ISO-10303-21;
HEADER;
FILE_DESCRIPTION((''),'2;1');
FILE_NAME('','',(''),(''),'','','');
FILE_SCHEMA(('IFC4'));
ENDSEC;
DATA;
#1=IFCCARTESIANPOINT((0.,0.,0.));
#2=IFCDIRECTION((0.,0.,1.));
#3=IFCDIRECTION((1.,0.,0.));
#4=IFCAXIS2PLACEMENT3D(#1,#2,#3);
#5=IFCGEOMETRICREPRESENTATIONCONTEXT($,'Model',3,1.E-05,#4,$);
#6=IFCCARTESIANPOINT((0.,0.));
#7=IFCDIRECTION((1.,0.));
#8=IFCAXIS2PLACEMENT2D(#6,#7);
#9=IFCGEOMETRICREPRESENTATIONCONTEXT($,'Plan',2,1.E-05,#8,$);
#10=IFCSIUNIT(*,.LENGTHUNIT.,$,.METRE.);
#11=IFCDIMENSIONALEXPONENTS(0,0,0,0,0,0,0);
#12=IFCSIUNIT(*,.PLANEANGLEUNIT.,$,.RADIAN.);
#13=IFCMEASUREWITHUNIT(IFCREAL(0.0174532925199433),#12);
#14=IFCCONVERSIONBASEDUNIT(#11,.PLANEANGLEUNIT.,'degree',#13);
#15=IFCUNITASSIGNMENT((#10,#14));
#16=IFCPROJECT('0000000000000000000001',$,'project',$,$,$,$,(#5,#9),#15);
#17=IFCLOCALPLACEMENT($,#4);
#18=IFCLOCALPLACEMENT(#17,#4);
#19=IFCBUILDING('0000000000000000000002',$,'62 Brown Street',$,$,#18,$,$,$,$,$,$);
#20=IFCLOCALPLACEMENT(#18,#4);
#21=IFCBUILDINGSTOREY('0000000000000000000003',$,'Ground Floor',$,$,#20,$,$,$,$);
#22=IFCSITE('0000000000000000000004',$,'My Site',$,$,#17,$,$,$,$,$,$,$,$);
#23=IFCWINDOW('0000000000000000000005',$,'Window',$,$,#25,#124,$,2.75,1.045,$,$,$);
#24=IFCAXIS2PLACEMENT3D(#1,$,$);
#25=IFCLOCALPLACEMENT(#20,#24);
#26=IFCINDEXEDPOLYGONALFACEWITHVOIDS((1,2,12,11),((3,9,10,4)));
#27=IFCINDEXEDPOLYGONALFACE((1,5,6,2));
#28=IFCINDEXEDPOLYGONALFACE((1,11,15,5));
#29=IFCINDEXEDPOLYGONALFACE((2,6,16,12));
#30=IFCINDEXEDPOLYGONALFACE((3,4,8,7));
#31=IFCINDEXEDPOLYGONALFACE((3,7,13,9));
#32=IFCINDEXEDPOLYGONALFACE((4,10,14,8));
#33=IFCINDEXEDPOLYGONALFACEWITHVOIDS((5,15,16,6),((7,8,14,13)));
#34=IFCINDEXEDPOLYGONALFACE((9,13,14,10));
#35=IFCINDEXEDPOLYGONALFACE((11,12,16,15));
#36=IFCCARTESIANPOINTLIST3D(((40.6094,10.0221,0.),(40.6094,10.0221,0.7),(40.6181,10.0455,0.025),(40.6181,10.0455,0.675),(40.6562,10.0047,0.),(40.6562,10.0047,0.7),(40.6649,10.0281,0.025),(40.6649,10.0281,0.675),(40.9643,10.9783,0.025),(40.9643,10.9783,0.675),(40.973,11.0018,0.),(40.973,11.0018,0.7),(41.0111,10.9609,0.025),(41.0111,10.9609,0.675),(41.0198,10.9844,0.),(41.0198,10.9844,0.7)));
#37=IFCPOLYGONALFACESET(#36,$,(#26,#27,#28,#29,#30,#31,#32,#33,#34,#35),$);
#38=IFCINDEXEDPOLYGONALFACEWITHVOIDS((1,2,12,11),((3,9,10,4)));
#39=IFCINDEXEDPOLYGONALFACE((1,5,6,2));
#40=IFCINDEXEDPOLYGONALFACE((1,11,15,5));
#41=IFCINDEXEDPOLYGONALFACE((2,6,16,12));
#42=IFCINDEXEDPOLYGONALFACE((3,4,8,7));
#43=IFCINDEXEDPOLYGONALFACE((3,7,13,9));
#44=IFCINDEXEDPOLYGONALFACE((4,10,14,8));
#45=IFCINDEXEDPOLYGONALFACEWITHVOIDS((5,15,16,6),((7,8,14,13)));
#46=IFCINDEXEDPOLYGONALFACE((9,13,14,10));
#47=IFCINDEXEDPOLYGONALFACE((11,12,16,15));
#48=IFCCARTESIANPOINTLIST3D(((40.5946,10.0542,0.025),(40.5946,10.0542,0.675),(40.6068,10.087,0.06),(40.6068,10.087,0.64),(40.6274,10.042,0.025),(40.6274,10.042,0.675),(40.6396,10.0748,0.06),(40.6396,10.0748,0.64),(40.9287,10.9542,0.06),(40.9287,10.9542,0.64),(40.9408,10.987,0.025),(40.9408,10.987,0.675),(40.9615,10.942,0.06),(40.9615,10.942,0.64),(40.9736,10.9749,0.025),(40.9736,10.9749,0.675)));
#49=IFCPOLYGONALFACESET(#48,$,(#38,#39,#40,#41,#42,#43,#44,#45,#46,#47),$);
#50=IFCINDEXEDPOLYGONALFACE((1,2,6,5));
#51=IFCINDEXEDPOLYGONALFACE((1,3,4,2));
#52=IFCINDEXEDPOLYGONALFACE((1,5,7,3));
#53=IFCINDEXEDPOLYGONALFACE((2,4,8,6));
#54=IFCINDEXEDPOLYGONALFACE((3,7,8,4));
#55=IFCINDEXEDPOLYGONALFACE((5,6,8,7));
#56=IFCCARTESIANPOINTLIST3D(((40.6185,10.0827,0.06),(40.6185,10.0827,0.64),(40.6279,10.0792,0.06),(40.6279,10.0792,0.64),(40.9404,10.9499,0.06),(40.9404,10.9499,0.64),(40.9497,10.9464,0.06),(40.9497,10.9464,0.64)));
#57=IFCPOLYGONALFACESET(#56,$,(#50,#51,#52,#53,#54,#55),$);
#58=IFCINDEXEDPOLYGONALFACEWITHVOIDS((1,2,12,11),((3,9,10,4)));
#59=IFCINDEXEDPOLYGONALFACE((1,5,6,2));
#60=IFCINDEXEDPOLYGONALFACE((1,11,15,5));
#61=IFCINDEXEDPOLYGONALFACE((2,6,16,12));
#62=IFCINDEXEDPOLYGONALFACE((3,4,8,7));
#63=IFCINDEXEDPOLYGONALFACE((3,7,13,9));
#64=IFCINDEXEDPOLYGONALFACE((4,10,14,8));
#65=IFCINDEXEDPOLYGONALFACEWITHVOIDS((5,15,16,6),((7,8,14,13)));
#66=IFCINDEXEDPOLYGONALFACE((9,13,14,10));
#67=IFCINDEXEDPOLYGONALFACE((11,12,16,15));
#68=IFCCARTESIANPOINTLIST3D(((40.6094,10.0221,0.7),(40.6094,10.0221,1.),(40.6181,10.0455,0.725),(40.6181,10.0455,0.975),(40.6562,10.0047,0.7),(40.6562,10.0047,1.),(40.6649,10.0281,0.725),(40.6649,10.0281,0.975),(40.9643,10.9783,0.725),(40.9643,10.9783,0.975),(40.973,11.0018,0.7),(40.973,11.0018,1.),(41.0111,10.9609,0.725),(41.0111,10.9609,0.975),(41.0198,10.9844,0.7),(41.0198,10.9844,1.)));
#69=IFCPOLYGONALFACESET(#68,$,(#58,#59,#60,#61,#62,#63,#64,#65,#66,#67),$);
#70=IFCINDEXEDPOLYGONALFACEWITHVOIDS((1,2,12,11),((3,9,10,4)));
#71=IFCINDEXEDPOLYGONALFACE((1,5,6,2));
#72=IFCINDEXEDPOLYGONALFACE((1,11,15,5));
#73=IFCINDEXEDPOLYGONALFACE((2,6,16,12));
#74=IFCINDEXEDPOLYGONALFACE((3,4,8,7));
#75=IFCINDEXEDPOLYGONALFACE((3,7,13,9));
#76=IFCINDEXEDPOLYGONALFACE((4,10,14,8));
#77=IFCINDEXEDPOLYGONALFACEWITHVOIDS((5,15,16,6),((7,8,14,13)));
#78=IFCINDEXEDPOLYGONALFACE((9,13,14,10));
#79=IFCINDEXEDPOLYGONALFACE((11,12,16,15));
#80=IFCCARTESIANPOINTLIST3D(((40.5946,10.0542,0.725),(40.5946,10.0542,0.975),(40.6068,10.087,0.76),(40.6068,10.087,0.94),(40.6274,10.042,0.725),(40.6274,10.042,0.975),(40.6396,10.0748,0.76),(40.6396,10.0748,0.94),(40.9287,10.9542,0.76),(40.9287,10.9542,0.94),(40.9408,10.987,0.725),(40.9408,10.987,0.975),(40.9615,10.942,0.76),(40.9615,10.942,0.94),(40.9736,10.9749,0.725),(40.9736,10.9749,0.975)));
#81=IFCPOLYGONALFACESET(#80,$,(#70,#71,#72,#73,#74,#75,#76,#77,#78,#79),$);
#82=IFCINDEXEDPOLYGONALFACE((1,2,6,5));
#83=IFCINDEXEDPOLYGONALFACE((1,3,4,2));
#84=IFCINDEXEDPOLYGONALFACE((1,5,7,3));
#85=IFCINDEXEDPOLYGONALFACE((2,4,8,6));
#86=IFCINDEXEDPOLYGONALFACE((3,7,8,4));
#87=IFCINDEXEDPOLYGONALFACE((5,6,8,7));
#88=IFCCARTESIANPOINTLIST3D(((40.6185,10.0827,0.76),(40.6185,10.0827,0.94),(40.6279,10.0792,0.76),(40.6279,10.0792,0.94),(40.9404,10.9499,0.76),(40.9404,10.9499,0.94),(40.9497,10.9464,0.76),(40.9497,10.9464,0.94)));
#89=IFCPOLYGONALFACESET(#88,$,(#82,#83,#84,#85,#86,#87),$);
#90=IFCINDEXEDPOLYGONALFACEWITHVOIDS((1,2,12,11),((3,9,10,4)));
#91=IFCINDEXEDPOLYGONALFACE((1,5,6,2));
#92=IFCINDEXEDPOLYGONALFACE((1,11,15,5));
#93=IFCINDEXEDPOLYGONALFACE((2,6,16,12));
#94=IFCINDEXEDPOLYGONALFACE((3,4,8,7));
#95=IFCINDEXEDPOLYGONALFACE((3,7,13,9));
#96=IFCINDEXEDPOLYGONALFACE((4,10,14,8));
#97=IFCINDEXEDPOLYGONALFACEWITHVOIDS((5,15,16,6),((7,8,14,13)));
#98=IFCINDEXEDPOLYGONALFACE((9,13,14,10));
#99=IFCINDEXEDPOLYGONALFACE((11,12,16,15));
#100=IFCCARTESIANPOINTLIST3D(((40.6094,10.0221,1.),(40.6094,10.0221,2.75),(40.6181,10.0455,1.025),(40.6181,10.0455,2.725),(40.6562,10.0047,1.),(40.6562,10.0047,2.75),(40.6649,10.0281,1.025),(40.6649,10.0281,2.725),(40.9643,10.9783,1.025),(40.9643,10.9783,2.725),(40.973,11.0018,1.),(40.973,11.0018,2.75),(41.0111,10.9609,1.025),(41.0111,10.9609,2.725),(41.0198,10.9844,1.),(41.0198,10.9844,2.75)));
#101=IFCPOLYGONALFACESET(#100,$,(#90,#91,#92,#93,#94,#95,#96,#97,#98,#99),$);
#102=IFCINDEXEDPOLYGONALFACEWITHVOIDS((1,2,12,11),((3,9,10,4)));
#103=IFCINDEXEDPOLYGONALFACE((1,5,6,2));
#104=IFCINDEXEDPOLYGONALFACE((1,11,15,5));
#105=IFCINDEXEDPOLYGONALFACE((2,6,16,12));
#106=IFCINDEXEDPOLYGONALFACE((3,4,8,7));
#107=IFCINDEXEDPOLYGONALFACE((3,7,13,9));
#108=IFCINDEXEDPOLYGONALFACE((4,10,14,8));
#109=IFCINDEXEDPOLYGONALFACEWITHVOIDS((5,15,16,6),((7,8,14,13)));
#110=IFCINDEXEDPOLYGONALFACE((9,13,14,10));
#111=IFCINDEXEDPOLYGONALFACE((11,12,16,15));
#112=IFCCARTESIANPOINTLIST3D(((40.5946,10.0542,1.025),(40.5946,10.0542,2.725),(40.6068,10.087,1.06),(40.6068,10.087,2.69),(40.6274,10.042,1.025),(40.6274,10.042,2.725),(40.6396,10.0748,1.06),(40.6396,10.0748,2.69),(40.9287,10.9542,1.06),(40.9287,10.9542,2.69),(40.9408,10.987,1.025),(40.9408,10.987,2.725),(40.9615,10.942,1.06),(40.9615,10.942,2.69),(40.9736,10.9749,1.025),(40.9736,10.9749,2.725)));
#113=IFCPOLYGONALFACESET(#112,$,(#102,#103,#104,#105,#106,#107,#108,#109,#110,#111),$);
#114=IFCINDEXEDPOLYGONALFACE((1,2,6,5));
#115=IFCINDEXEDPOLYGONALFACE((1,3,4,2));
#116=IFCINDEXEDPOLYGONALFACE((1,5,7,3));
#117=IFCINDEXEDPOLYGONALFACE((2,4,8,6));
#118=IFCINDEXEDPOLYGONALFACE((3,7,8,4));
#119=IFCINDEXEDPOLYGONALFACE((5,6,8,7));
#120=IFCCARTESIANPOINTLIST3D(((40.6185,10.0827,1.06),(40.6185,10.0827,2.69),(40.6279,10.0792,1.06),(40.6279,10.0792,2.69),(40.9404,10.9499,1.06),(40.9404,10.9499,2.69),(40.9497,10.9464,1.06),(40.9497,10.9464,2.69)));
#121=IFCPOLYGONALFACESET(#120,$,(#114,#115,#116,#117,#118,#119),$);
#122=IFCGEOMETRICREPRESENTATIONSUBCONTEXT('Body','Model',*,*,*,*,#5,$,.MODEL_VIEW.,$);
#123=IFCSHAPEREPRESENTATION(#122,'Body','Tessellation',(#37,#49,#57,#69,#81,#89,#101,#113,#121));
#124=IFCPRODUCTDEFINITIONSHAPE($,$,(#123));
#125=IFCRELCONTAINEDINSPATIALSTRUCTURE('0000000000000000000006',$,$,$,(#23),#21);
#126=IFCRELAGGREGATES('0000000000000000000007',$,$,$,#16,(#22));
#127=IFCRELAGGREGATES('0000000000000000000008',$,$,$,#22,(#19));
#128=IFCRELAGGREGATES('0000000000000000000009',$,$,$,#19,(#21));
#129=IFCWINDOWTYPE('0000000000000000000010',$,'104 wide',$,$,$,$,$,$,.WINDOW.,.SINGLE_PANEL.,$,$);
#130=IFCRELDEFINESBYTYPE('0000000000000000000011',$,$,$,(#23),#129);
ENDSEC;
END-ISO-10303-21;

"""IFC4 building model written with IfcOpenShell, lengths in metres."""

from ifc_helpers import new_model, entity, si_unit, converted_unit, frame, origin_with_axes, origin_2d_with_axis, place, context, subcontext, project, spatial, line, indexed_curve, outline, extrude, shape, source, transform, mapped, type_object, type_shapes, element, save


model = new_model("IFC4")

# Units and contexts
model_context = context("Model", 3, precision=1e-05, world=origin_with_axes())
plan_context = context("Plan", 2, precision=1e-05, world=origin_2d_with_axis())
body_context_1 = subcontext(model_context, "Body", "Model", "MODEL_VIEW")
body_context_2 = subcontext(plan_context, "Body", "Plan", "PLAN_VIEW")
ifc_project = project(units=[si_unit("LENGTHUNIT", "METRE"), converted_unit("PLANEANGLEUNIT", "degree", entity("IfcReal", 0.0174532925199433), si_unit("PLANEANGLEUNIT", "RADIAN"), dimensions=[0, 0, 0, 0, 0, 0, 0])], contexts=[model_context, plan_context])

# Site, building, storey
site_placement = place(None, origin_with_axes())
site = spatial("IfcSite", under=ifc_project, at=site_placement, Name="My Site")
building_placement = place(site_placement, origin_with_axes())
building = spatial("IfcBuilding", under=site, at=building_placement, Name="62 Brown Street")
storey_placement = place(building_placement, origin_with_axes())
storey = spatial("IfcBuildingStorey", under=building, at=storey_placement, Name="Ground Floor")

# Window
window_type_1 = type_object("IfcWindowType", Name="104 wide", PartitioningType="SINGLE_PANEL", PredefinedType="WINDOW")
shared_shape_1 = source(origin_with_axes(), body_context_1, "Body", "SweptSolid", [
    extrude(outline(indexed_curve([(0.0, 0.0), (1.045, 0.0), (1.045, 0.7), (0.0, 0.7)], segments=[line(1, 2, 3, 4, 1)]), holes=[indexed_curve([(0.025, 0.025), (1.02, 0.025), (1.02, 0.675), (0.025, 0.675)], segments=[line(1, 2, 3, 4, 1)])]), frame((0.0, 0.15, 0.0), z_axis=(0.0, -1.0, 0.0), x_axis=(1.0, 0.0, 0.0)), (0.0, 0.0, -1.0), 0.05),
    extrude(outline(indexed_curve([(0.0, 0.0), (0.995, 0.0), (0.995, 0.65), (0.0, 0.65)], segments=[line(1, 2, 3, 4, 1)]), holes=[indexed_curve([(0.035, 0.035), (0.96, 0.035), (0.96, 0.615), (0.035, 0.615)], segments=[line(1, 2, 3, 4, 1)])]), frame((0.025, 0.19, 0.025), z_axis=(0.0, -1.0, 0.0), x_axis=(1.0, 0.0, 0.0)), (0.0, 0.0, -1.0), 0.035),
    extrude(outline(indexed_curve([(0.035, 0.035), (0.96, 0.035), (0.96, 0.615), (0.035, 0.615)], segments=[line(1, 2, 3, 4, 1)])), frame((0.025, 0.2025, 0.025), z_axis=(0.0, -1.0, 0.0), x_axis=(1.0, 0.0, 0.0)), (0.0, 0.0, -1.0), 0.01),
    extrude(outline(indexed_curve([(0.0, 0.0), (1.045, 0.0), (1.045, 0.3), (0.0, 0.3)], segments=[line(1, 2, 3, 4, 1)]), holes=[indexed_curve([(0.025, 0.025), (1.02, 0.025), (1.02, 0.275), (0.025, 0.275)], segments=[line(1, 2, 3, 4, 1)])]), frame((0.0, 0.15, 0.7), z_axis=(0.0, -1.0, 0.0), x_axis=(1.0, 0.0, 0.0)), (0.0, 0.0, -1.0), 0.05),
    extrude(outline(indexed_curve([(0.0, 0.0), (0.995, 0.0), (0.995, 0.25), (0.0, 0.25)], segments=[line(1, 2, 3, 4, 1)]), holes=[indexed_curve([(0.035, 0.035), (0.96, 0.035), (0.96, 0.215), (0.035, 0.215)], segments=[line(1, 2, 3, 4, 1)])]), frame((0.025, 0.19, 0.725), z_axis=(0.0, -1.0, 0.0), x_axis=(1.0, 0.0, 0.0)), (0.0, 0.0, -1.0), 0.035),
    extrude(outline(indexed_curve([(0.035, 0.035), (0.96, 0.035), (0.96, 0.215), (0.035, 0.215)], segments=[line(1, 2, 3, 4, 1)])), frame((0.025, 0.2025, 0.725), z_axis=(0.0, -1.0, 0.0), x_axis=(1.0, 0.0, 0.0)), (0.0, 0.0, -1.0), 0.01),
    extrude(outline(indexed_curve([(0.0, 0.0), (1.045, 0.0), (1.045, 1.75), (0.0, 1.75)], segments=[line(1, 2, 3, 4, 1)]), holes=[indexed_curve([(0.025, 0.025), (1.02, 0.025), (1.02, 1.725), (0.025, 1.725)], segments=[line(1, 2, 3, 4, 1)])]), frame((0.0, 0.15, 1.0), z_axis=(0.0, -1.0, 0.0), x_axis=(1.0, 0.0, 0.0)), (0.0, 0.0, -1.0), 0.05),
    extrude(outline(indexed_curve([(0.0, 0.0), (0.995, 0.0), (0.995, 1.7), (0.0, 1.7)], segments=[line(1, 2, 3, 4, 1)]), holes=[indexed_curve([(0.035, 0.035), (0.96, 0.035), (0.96, 1.665), (0.035, 1.665)], segments=[line(1, 2, 3, 4, 1)])]), frame((0.025, 0.19, 1.025), z_axis=(0.0, -1.0, 0.0), x_axis=(1.0, 0.0, 0.0)), (0.0, 0.0, -1.0), 0.035),
    extrude(outline(indexed_curve([(0.035, 0.035), (0.96, 0.035), (0.96, 1.665), (0.035, 1.665)], segments=[line(1, 2, 3, 4, 1)])), frame((0.025, 0.2025, 1.025), z_axis=(0.0, -1.0, 0.0), x_axis=(1.0, 0.0, 0.0)), (0.0, 0.0, -1.0), 0.01),
])
shared_shape_2 = source(origin_with_axes(), body_context_2, "Body", "Curve2D", [
    entity("IfcIndexedPolyCurve", entity("IfcCartesianPointList2D", [[0.025, 0.15], [1.02, 0.15]])),
    entity("IfcIndexedPolyCurve", entity("IfcCartesianPointList2D", [[0.0, 0.2], [0.025, 0.2], [0.025, 0.15], [0.0, 0.15]]), [entity("IfcLineIndex", [1, 2, 3, 4, 1])]),
    entity("IfcIndexedPolyCurve", entity("IfcCartesianPointList2D", [[1.045, 0.2], [1.02, 0.2], [1.02, 0.15], [1.045, 0.15]]), [entity("IfcLineIndex", [1, 2, 3, 4, 1])]),
    entity("IfcIndexedPolyCurve", entity("IfcCartesianPointList2D", [[0.025, 0.19], [0.06, 0.19], [0.06, 0.225], [0.025, 0.225]]), [entity("IfcLineIndex", [1, 2, 3, 4, 1])]),
    entity("IfcIndexedPolyCurve", entity("IfcCartesianPointList2D", [[1.02, 0.19], [0.985, 0.19], [0.985, 0.225], [1.02, 0.225]]), [entity("IfcLineIndex", [1, 2, 3, 4, 1])]),
    entity("IfcIndexedPolyCurve", entity("IfcCartesianPointList2D", [[0.06, 0.19], [0.985, 0.19]])),
    entity("IfcIndexedPolyCurve", entity("IfcCartesianPointList2D", [[0.06, 0.225], [0.985, 0.225]])),
    entity("IfcIndexedPolyCurve", entity("IfcCartesianPointList2D", [[0.06, 0.2075], [0.985, 0.2075]])),
])
type_shapes(window_type_1, [shared_shape_1, shared_shape_2])
placement_1 = place(storey_placement, frame((39.024, 5.1755, 0.0), z_axis=(0.0, 0.0, 1.0), x_axis=(0.347944, 0.937515, 0.0)))
placement_2 = place(placement_1, frame((5.0954, 0.0, 0.0), z_axis=(0.0, 0.0, 1.0), x_axis=(1.0, 0.0, 0.0)))
window_1_placement = place(placement_2, origin_with_axes())
element("IfcWindow", 1, at=window_1_placement, inside=storey, type_object=window_type_1, Name="Window", OverallHeight=2.75, OverallWidth=1.045, shapes=[
    shape(body_context_1, "Body", "MappedRepresentation", [mapped(shared_shape_1, transform((0.0, 0.0, 0.0), x_axis=(1.0, 0.0, 0.0), y_axis=(0.0, 1.0, 0.0), z_axis=(0.0, 0.0, 1.0), scale=1.0))]),
    shape(body_context_2, "Body", "MappedRepresentation", [mapped(shared_shape_2, transform((0.0, 0.0, 0.0), x_axis=(1.0, 0.0, 0.0), y_axis=(0.0, 1.0, 0.0), z_axis=(0.0, 0.0, 1.0), scale=1.0))]),
])

save(model, "model.ifc")
